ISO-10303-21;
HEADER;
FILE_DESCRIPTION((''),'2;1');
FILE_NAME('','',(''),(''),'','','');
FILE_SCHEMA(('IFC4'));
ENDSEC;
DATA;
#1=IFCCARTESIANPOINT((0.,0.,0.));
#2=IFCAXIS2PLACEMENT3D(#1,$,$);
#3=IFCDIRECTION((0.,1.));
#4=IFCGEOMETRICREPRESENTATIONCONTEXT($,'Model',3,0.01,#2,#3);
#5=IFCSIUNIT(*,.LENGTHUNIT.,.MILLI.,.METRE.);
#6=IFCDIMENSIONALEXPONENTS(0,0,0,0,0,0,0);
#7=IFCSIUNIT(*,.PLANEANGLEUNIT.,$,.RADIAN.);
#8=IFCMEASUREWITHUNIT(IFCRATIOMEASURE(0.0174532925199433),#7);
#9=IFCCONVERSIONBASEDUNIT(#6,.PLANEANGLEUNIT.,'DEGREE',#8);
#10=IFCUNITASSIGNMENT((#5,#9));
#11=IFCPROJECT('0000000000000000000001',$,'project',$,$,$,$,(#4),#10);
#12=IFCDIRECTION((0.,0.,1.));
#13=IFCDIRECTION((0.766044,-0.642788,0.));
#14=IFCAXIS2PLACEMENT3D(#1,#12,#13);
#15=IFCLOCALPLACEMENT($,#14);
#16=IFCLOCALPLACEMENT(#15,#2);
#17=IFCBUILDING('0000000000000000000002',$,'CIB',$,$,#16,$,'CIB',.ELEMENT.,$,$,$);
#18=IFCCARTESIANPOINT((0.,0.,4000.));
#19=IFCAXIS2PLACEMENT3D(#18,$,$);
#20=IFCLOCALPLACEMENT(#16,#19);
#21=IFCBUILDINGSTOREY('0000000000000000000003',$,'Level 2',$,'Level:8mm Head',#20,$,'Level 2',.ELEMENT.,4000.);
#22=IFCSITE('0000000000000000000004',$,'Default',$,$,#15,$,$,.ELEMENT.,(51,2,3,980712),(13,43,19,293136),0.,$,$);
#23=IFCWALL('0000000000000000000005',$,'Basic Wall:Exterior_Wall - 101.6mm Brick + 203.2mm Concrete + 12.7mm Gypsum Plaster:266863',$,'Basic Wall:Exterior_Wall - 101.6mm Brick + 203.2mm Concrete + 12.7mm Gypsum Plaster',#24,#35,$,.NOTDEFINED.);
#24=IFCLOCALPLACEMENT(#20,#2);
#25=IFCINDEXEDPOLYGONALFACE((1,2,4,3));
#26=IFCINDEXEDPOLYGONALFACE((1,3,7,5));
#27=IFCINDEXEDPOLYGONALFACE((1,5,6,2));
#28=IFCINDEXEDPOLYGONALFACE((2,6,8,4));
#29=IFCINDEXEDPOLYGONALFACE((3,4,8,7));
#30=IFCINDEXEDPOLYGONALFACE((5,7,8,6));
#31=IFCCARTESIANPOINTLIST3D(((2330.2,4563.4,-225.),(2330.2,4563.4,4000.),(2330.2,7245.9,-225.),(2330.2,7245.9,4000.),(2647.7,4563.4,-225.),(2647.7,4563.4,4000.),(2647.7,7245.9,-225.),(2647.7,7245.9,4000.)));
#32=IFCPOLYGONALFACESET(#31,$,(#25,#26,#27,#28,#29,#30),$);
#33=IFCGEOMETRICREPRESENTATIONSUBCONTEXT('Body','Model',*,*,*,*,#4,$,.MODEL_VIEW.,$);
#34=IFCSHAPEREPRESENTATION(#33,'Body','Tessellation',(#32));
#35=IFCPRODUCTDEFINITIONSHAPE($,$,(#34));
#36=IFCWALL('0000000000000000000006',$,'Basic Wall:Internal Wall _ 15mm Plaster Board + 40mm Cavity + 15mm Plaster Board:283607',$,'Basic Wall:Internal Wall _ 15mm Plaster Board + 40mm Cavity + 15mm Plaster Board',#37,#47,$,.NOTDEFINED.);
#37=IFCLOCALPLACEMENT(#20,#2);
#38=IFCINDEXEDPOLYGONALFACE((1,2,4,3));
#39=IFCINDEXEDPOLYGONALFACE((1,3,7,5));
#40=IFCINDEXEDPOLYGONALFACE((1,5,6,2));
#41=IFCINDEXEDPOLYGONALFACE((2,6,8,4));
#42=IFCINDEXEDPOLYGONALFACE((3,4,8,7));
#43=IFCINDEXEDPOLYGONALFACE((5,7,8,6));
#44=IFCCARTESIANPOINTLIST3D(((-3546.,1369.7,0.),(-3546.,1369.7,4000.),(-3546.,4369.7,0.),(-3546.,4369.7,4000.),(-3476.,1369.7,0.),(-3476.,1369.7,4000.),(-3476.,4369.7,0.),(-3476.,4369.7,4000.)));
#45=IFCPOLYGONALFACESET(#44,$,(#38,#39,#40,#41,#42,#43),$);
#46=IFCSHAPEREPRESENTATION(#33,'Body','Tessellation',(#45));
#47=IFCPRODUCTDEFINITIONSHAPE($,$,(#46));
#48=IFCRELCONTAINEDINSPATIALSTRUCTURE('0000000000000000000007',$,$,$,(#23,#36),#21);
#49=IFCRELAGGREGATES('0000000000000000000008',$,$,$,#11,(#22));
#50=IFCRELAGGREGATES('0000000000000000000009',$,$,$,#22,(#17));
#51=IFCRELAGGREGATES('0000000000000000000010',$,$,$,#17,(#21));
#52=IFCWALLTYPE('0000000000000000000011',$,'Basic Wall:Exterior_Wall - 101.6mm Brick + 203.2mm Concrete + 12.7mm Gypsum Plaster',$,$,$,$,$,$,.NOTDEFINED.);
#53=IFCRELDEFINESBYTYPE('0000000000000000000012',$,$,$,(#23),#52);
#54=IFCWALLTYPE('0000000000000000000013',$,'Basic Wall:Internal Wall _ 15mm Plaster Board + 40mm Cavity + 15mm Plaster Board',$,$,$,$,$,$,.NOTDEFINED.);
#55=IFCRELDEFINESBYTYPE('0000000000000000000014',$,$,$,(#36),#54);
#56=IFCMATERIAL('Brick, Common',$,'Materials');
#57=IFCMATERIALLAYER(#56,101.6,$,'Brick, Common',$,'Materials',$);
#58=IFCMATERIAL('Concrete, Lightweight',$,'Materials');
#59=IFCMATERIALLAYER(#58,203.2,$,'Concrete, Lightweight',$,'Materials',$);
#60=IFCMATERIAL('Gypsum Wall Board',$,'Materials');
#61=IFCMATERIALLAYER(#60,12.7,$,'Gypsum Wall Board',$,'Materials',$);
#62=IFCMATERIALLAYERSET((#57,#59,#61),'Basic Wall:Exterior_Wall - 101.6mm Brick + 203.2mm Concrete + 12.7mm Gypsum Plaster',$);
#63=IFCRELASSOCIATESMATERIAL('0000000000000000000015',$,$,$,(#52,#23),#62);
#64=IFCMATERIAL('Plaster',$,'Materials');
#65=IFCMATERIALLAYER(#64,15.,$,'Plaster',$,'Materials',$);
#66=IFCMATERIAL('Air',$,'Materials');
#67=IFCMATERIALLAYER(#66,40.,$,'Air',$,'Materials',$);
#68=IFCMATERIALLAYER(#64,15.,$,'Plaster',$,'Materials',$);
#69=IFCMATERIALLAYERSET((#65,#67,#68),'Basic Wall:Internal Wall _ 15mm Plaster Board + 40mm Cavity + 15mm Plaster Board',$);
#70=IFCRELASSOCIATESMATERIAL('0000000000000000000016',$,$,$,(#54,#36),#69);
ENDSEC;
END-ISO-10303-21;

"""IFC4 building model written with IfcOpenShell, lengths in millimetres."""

from ifc_helpers import new_model, entity, si_unit, converted_unit, direction, frame, origin, place, context, subcontext, project, spatial, indexed_curve, outline, extrude, material, layer, layer_set, type_object, element, save


model = new_model("IFC4")

# Units and contexts
model_context = context("Model", 3, precision=0.01, world=origin(), true_north=direction((0.0, 1.0)))
body_context = subcontext(model_context, "Body", "Model", "MODEL_VIEW")
ifc_project = project(units=[si_unit("LENGTHUNIT", "METRE", prefix="MILLI"), converted_unit("PLANEANGLEUNIT", "DEGREE", entity("IfcRatioMeasure", 0.0174532925199433), si_unit("PLANEANGLEUNIT", "RADIAN"), dimensions=[0, 0, 0, 0, 0, 0, 0])], contexts=[model_context])

# Site, building, storey
site_placement = place(None, frame((0.0, 0.0, 0.0), z_axis=(0.0, 0.0, 1.0), x_axis=(0.766044, -0.642788, 0.0)))
site = spatial("IfcSite", under=ifc_project, at=site_placement, Name="Default", CompositionType="ELEMENT", RefLatitude=(51, 2, 3, 980712), RefLongitude=(13, 43, 19, 293136), RefElevation=0.0)
building_placement = place(site_placement, origin())
building = spatial("IfcBuilding", under=site, at=building_placement, Name="CIB", LongName="CIB", CompositionType="ELEMENT")
storey_placement = place(building_placement, frame((0.0, 0.0, 4000.0)))
storey = spatial("IfcBuildingStorey", under=building, at=storey_placement, Name="Level 2", ObjectType="Level:8mm Head", LongName="Level 2", CompositionType="ELEMENT", Elevation=4000.0)

# Shared definitions
ifc_material_1 = material(Name="Plaster", Category="Materials")

# Walls
ifc_material_2 = material(Name="Brick, Common", Category="Materials")
ifc_layer_1 = layer(ifc_material_2, 101.6, Name="Brick, Common", Category="Materials")
ifc_material_3 = material(Name="Concrete, Lightweight", Category="Materials")
ifc_layer_2 = layer(ifc_material_3, 203.2, Name="Concrete, Lightweight", Category="Materials")
ifc_material_4 = material(Name="Gypsum Wall Board", Category="Materials")
ifc_layer_3 = layer(ifc_material_4, 12.7, Name="Gypsum Wall Board", Category="Materials")
ifc_layer_set_1 = layer_set([ifc_layer_1, ifc_layer_2, ifc_layer_3], Name="Basic Wall:Exterior_Wall - 101.6mm Brick + 203.2mm Concrete + 12.7mm Gypsum Plaster")
wall_type_1 = type_object("IfcWallType", Name="Basic Wall:Exterior_Wall - 101.6mm Brick + 203.2mm Concrete + 12.7mm Gypsum Plaster", PredefinedType="NOTDEFINED", material=ifc_layer_set_1)
wall_1_placement = place(storey_placement, frame((2489.0, 7245.9, -225.0), z_axis=(0.0, 0.0, 1.0), x_axis=(0.0, -1.0, 0.0)))
element("IfcWall", 1, at=wall_1_placement, inside=storey, type_object=wall_type_1, material=ifc_layer_set_1, Name="Basic Wall:Exterior_Wall - 101.6mm Brick + 203.2mm Concrete + 12.7mm Gypsum Plaster:266863", ObjectType="Basic Wall:Exterior_Wall - 101.6mm Brick + 203.2mm Concrete + 12.7mm Gypsum Plaster", PredefinedType="NOTDEFINED", context=body_context, shape_type="SweptSolid", body=[
    extrude(outline(indexed_curve([(2682.5, 158.8), (0.0, 158.8), (0.0, -158.8), (2682.5, -158.8), (2682.5, 158.8)], self_intersect=False)), origin(), (0.0, 0.0, 1.0), 4225.0),
])
ifc_layer_4 = layer(ifc_material_1, 15.0, Name="Plaster", Category="Materials")
ifc_material_5 = material(Name="Air", Category="Materials")
ifc_layer_5 = layer(ifc_material_5, 40.0, Name="Air", Category="Materials")
ifc_layer_6 = layer(ifc_material_1, 15.0, Name="Plaster", Category="Materials")
ifc_layer_set_2 = layer_set([ifc_layer_4, ifc_layer_5, ifc_layer_6], Name="Basic Wall:Internal Wall _ 15mm Plaster Board + 40mm Cavity + 15mm Plaster Board")
wall_type_2 = type_object("IfcWallType", Name="Basic Wall:Internal Wall _ 15mm Plaster Board + 40mm Cavity + 15mm Plaster Board", PredefinedType="NOTDEFINED", material=ifc_layer_set_2)
wall_2_placement = place(storey_placement, frame((-3511.0, 4369.7, 0.0), z_axis=(0.0, 0.0, 1.0), x_axis=(0.0, -1.0, 0.0)))
element("IfcWall", 2, at=wall_2_placement, inside=storey, type_object=wall_type_2, material=ifc_layer_set_2, Name="Basic Wall:Internal Wall _ 15mm Plaster Board + 40mm Cavity + 15mm Plaster Board:283607", ObjectType="Basic Wall:Internal Wall _ 15mm Plaster Board + 40mm Cavity + 15mm Plaster Board", PredefinedType="NOTDEFINED", context=body_context, shape_type="SweptSolid", body=[
    extrude(outline(indexed_curve([(3000.0, 35.0), (0.0, 35.0), (0.0, -35.0), (3000.0, -35.0), (3000.0, 35.0)], self_intersect=False)), origin(), (0.0, 0.0, 1.0), 4000.0),
])

save(model, "model.ifc")
